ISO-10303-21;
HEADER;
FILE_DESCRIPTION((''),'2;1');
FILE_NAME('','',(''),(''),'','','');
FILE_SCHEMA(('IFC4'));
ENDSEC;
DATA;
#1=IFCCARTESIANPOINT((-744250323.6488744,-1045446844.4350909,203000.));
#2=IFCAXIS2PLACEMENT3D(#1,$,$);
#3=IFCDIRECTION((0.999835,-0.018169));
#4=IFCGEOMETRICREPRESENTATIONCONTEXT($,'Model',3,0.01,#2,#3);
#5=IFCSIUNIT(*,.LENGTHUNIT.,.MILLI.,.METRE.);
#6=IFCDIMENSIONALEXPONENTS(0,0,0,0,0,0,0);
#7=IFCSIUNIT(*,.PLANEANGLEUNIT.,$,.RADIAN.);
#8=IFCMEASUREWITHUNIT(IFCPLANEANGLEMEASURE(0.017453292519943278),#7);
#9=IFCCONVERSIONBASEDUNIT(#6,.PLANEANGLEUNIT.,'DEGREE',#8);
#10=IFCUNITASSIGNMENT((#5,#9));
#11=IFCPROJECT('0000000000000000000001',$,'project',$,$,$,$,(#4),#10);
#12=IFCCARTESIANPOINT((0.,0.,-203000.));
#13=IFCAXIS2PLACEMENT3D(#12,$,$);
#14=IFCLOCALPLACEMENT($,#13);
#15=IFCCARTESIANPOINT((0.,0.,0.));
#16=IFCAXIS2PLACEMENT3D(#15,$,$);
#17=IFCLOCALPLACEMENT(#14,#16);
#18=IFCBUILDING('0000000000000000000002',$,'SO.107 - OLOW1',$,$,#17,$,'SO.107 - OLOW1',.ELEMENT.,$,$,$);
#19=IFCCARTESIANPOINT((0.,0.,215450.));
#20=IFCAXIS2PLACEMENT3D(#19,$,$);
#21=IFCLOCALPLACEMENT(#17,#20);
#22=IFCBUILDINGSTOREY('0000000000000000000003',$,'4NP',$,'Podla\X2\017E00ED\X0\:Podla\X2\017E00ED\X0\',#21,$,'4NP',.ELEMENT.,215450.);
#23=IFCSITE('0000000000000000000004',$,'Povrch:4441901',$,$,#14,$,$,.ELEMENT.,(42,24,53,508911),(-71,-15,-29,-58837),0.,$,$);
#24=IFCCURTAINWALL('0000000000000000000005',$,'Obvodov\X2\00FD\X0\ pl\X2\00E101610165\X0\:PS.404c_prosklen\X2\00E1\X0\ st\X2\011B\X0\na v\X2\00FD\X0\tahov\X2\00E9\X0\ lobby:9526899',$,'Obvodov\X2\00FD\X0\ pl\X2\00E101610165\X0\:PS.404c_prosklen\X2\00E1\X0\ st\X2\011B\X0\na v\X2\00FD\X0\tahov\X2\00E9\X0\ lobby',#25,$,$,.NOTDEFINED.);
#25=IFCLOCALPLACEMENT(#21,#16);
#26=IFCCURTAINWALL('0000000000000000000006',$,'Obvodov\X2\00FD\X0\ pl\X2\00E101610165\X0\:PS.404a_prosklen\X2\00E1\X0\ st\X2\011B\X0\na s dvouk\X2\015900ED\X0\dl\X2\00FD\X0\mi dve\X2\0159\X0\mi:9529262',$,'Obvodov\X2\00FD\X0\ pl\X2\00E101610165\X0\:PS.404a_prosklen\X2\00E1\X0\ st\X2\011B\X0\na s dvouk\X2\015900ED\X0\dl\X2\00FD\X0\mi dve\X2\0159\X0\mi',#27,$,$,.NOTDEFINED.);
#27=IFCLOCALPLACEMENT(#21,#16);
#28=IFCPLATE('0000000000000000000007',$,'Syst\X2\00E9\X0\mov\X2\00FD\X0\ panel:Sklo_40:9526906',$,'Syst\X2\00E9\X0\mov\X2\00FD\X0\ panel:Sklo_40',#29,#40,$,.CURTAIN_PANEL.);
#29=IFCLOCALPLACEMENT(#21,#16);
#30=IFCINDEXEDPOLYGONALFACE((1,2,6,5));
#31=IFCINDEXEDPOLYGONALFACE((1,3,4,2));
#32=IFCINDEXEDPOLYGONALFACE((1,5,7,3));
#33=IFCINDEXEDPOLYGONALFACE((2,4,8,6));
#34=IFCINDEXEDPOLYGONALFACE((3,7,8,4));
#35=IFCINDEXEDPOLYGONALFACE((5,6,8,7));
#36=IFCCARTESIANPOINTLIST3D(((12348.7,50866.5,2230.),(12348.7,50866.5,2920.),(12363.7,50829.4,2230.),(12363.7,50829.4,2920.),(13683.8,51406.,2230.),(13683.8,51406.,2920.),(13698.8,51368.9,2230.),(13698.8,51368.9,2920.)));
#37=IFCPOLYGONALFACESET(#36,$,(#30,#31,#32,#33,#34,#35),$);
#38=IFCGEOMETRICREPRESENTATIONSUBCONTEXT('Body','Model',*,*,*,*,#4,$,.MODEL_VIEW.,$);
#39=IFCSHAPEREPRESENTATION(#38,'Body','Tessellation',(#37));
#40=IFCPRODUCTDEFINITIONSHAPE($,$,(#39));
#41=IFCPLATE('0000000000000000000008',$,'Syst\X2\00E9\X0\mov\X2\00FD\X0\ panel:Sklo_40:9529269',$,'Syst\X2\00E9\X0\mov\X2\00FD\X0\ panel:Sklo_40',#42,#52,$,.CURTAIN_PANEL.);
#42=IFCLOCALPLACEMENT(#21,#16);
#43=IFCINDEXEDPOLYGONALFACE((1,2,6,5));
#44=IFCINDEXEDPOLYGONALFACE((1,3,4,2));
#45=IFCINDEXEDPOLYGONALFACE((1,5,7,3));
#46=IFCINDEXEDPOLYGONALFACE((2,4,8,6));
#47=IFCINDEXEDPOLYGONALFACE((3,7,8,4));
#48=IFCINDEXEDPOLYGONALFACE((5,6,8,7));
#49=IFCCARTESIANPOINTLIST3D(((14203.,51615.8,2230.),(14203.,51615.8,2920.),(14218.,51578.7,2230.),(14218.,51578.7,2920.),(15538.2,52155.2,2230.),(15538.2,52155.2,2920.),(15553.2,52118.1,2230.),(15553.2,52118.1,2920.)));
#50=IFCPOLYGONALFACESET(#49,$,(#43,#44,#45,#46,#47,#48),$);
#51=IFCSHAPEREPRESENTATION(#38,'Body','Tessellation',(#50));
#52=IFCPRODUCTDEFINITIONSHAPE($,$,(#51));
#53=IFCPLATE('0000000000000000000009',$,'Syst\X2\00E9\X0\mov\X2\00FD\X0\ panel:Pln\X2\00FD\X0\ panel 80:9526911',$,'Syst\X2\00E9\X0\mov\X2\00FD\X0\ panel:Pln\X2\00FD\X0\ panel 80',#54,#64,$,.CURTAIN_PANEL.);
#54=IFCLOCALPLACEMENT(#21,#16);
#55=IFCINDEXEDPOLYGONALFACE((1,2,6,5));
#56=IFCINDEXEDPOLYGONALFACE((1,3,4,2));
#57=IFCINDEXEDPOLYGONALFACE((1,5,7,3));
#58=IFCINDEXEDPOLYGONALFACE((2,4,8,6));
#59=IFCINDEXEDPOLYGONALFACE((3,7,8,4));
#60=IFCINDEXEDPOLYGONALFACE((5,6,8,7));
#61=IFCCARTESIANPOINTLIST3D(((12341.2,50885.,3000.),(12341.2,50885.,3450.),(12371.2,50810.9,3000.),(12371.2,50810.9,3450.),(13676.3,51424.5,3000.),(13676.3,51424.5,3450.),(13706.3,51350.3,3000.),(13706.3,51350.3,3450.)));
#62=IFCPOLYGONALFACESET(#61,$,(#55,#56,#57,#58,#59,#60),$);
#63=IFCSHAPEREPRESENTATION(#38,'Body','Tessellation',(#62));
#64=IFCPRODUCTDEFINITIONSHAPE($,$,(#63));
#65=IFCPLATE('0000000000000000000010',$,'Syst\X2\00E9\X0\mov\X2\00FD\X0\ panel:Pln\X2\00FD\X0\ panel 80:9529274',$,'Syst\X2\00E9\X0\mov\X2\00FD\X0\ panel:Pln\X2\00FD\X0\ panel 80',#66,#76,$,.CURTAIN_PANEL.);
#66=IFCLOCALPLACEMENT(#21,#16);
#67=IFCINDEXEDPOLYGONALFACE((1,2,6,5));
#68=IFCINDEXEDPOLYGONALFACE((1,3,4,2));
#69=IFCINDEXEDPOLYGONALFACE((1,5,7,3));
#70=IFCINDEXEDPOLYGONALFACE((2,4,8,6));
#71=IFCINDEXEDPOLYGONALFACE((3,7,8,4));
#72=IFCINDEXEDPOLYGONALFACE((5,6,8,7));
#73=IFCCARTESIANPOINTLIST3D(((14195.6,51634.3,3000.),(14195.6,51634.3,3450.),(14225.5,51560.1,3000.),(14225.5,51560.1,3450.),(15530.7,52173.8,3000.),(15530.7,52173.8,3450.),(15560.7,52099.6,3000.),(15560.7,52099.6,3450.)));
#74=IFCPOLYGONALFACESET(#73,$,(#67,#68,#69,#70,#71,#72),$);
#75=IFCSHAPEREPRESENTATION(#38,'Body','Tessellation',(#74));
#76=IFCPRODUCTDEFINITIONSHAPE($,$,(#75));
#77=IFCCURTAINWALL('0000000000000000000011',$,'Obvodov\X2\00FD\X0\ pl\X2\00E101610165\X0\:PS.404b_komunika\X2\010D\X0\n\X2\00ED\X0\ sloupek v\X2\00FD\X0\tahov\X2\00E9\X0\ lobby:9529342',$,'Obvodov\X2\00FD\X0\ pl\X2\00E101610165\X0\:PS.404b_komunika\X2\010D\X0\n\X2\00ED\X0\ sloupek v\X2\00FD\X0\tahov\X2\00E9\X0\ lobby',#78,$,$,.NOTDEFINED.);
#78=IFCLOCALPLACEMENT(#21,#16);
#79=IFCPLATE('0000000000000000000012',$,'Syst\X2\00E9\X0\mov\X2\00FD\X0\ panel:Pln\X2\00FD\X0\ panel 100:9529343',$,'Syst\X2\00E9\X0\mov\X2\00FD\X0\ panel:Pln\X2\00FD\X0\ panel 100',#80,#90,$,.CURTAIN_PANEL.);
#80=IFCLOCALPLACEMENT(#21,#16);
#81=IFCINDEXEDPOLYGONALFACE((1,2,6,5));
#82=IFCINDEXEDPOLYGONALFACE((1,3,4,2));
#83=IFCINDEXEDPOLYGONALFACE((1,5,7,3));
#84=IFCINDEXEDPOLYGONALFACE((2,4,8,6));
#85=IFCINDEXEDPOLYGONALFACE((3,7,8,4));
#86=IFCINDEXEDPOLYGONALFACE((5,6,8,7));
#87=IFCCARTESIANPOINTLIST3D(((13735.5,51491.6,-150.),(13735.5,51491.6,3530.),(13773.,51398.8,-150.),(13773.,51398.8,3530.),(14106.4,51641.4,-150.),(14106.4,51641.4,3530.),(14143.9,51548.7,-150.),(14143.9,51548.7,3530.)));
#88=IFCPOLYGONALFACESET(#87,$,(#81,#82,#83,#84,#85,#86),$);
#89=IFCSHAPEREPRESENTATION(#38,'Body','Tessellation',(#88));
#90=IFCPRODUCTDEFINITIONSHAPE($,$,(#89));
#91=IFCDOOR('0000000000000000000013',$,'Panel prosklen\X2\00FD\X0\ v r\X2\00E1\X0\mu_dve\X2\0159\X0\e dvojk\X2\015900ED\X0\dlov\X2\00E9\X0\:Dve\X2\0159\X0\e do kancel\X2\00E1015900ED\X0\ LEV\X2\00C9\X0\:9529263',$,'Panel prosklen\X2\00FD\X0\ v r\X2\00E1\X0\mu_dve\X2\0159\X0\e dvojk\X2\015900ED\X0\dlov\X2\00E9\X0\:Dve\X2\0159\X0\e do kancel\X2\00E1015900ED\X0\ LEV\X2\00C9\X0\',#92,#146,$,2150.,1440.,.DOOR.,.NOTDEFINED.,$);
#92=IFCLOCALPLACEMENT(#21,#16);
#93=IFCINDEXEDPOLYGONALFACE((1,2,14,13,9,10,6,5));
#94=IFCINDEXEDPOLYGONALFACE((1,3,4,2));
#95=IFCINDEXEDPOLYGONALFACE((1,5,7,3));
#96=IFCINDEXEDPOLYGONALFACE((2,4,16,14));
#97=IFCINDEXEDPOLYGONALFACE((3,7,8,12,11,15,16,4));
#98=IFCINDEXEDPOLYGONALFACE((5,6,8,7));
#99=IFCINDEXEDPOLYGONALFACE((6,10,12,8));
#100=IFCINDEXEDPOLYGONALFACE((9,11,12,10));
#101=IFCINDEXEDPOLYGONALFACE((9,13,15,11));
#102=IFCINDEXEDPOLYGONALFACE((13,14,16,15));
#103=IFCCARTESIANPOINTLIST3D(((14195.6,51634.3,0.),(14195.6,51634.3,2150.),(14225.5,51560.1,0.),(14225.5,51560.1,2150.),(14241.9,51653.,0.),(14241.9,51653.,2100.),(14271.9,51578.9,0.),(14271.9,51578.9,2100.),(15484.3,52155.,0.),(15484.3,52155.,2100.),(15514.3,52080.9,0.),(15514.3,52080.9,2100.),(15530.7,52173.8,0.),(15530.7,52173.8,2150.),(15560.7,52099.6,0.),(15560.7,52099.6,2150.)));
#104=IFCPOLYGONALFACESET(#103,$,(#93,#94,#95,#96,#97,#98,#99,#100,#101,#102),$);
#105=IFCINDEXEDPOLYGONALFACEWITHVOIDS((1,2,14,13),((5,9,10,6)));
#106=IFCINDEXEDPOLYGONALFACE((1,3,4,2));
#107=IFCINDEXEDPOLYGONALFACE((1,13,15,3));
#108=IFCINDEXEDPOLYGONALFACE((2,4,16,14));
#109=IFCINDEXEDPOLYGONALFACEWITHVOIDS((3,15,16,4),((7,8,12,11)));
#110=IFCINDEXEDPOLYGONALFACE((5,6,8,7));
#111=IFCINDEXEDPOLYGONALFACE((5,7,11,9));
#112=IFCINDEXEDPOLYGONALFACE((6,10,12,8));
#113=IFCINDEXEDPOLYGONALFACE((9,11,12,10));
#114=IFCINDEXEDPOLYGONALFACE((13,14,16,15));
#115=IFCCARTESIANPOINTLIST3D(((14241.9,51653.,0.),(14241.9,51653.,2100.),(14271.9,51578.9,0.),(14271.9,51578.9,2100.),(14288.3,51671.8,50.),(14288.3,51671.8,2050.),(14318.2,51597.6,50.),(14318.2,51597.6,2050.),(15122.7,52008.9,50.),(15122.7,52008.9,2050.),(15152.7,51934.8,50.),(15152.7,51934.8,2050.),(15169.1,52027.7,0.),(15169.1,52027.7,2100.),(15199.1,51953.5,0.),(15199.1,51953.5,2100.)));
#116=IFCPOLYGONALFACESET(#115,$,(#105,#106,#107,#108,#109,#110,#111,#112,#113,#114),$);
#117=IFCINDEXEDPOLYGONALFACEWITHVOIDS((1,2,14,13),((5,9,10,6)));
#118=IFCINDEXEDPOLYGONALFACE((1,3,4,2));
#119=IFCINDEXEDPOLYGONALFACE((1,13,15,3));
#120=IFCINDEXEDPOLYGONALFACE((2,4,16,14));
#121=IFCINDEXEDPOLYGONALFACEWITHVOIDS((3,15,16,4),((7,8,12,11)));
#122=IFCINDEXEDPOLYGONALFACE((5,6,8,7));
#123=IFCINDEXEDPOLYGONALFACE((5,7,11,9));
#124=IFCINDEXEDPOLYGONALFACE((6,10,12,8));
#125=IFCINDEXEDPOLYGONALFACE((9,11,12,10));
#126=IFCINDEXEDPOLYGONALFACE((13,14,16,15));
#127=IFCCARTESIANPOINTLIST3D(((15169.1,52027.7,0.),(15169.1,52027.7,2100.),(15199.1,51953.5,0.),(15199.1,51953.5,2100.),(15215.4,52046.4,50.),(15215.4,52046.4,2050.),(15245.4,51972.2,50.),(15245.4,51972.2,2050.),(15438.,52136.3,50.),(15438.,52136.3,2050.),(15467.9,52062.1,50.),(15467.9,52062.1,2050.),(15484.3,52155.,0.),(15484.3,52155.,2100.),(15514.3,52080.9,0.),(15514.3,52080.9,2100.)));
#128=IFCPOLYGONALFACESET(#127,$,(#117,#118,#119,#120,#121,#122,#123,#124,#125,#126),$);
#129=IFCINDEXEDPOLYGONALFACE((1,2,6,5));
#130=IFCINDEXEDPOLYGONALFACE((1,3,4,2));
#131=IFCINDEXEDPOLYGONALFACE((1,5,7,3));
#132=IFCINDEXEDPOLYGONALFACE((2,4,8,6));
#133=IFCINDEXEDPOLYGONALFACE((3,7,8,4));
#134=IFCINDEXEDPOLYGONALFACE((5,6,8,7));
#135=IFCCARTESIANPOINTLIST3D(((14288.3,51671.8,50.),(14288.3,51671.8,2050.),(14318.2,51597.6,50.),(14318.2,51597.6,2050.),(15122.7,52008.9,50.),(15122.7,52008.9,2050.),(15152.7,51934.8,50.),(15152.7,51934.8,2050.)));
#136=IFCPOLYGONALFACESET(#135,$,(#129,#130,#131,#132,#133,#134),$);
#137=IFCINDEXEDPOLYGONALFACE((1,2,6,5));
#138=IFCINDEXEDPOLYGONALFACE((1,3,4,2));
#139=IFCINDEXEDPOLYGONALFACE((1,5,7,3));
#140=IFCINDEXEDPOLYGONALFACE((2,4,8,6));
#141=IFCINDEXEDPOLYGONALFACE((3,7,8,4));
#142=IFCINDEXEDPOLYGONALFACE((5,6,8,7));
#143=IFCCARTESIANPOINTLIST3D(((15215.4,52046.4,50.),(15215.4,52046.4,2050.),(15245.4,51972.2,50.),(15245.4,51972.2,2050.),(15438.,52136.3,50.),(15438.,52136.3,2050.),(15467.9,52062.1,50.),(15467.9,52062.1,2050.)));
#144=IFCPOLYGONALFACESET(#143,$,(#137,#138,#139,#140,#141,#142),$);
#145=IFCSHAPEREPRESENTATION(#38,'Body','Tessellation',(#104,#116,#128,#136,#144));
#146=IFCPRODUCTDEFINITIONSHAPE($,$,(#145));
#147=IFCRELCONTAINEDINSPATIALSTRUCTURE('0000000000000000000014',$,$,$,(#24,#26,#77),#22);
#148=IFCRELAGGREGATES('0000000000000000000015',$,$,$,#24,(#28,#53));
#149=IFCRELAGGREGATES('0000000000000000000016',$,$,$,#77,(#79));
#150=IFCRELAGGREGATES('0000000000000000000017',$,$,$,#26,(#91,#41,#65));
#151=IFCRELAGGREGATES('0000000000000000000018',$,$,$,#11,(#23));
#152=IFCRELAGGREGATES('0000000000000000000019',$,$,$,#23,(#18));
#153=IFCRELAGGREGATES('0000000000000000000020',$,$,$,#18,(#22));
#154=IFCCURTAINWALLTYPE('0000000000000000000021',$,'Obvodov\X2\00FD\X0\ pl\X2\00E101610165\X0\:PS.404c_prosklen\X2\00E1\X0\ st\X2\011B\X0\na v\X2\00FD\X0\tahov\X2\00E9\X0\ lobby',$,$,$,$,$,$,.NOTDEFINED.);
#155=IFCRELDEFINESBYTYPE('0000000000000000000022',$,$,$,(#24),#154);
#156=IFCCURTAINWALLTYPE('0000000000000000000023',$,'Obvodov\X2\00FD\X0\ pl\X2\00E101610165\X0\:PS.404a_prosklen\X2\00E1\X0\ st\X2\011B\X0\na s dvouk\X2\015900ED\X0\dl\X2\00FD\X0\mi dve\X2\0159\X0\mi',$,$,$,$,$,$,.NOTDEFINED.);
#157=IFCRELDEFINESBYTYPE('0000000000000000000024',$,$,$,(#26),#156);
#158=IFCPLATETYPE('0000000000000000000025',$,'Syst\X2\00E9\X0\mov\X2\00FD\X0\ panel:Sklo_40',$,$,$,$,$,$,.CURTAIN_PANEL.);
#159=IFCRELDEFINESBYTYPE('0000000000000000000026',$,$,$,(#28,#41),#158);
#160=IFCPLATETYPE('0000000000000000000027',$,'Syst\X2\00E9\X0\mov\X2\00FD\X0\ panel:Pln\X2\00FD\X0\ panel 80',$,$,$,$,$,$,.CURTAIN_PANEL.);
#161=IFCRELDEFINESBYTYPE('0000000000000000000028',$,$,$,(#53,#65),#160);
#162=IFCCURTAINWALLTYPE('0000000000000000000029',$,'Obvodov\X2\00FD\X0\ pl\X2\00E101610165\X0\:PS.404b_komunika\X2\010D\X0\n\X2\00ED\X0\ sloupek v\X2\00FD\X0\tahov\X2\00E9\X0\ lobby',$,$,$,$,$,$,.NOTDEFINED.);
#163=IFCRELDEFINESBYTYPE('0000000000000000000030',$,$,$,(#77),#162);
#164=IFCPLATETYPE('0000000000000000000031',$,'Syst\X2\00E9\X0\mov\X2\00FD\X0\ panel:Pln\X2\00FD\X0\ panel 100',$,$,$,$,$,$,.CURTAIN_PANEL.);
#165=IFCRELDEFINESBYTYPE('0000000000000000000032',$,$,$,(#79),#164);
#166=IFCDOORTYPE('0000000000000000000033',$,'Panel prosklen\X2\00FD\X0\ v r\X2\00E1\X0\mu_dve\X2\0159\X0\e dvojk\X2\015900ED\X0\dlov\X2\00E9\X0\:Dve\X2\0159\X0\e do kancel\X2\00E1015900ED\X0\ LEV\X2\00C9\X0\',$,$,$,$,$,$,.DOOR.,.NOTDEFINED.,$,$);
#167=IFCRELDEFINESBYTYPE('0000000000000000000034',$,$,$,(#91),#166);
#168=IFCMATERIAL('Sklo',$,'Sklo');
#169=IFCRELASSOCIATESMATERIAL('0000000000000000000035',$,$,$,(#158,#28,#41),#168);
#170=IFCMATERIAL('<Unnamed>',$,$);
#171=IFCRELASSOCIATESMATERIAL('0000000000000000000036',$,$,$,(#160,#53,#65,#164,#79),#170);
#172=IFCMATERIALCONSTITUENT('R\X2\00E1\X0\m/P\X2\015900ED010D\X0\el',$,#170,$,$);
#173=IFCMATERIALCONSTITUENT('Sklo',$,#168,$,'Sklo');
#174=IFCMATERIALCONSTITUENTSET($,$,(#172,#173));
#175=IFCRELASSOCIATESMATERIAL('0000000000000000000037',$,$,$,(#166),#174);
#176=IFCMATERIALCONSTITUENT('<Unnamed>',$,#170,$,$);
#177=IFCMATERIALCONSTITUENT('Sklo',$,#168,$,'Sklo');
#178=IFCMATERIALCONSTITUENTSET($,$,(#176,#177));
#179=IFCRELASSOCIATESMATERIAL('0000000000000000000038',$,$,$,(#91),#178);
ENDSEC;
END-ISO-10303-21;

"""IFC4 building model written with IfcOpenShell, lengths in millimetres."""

from ifc_helpers import new_model, entity, si_unit, converted_unit, direction, frame, origin, place, context, subcontext, project, spatial, indexed_curve, outline, extrude, source, transform, mapped, material, constituent, constituent_set, type_object, type_shapes, element, aggregate, save


model = new_model("IFC4")

# Units and contexts
model_context = context("Model", 3, precision=0.01, world=frame((-744250323.6488744, -1045446844.4350909, 203000.0)), true_north=direction((0.999835, -0.018169)))
body_context = subcontext(model_context, "Body", "Model", "MODEL_VIEW")
ifc_project = project(units=[si_unit("LENGTHUNIT", "METRE", prefix="MILLI"), converted_unit("PLANEANGLEUNIT", "DEGREE", entity("IfcPlaneAngleMeasure", 0.017453292519943278), si_unit("PLANEANGLEUNIT", "RADIAN"), dimensions=[0, 0, 0, 0, 0, 0, 0])], contexts=[model_context])

# Site, building, storey
site_placement = place(None, frame((0.0, 0.0, -203000.0)))
site = spatial("IfcSite", under=ifc_project, at=site_placement, Name="Povrch:4441901", CompositionType="ELEMENT", RefLatitude=(42, 24, 53, 508911), RefLongitude=(-71, -15, -29, -58837), RefElevation=0.0)
building_placement = place(site_placement, origin())
building = spatial("IfcBuilding", under=site, at=building_placement, Name="SO.107 - OLOW1", LongName="SO.107 - OLOW1", CompositionType="ELEMENT")
storey_placement = place(building_placement, frame((0.0, 0.0, 215450.0)))
storey = spatial("IfcBuildingStorey", under=building, at=storey_placement, Name="4NP", ObjectType="Podlaží:Podlaží", LongName="4NP", CompositionType="ELEMENT", Elevation=215450.0)

# Curtain walls
curtain_wall_type_1 = type_object("IfcCurtainWallType", Name="Obvodový plášť:PS.404c_prosklená stěna výtahové lobby", PredefinedType="NOTDEFINED")
curtain_wall_1_placement = place(storey_placement, frame((0.0, 0.0, -215450.0)))
curtain_wall_1 = element("IfcCurtainWall", 1, at=curtain_wall_1_placement, inside=storey, type_object=curtain_wall_type_1, Name="Obvodový plášť:PS.404c_prosklená stěna výtahové lobby:9526899", ObjectType="Obvodový plášť:PS.404c_prosklená stěna výtahové lobby", PredefinedType="NOTDEFINED")
ifc_material_1 = material(Name="<Unnamed>")
curtain_wall_type_2 = type_object("IfcCurtainWallType", Name="Obvodový plášť:PS.404a_prosklená stěna s dvoukřídlými dveřmi", PredefinedType="NOTDEFINED")
curtain_wall_2_placement = place(storey_placement, frame((0.0, 0.0, -215450.0)))
curtain_wall_2 = element("IfcCurtainWall", 2, at=curtain_wall_2_placement, inside=storey, type_object=curtain_wall_type_2, Name="Obvodový plášť:PS.404a_prosklená stěna s dvoukřídlými dveřmi:9529262", ObjectType="Obvodový plášť:PS.404a_prosklená stěna s dvoukřídlými dveřmi", PredefinedType="NOTDEFINED")

# Plates
ifc_material_2 = material(Name="Sklo", Category="Sklo")
plate_type_1 = type_object("IfcPlateType", Name="Systémový panel:Sklo_40", PredefinedType="CURTAIN_PANEL", material=ifc_material_2)
shared_shape_1 = source(origin(), body_context, "Body", "SweptSolid", [
    extrude(outline(indexed_curve([(-20.0, -720.0), (20.0, -720.0), (20.0, 720.0), (-20.0, 720.0), (-20.0, -720.0)], self_intersect=False)), frame((0.0, 0.0, 0.0), z_axis=(0.0, 0.0, 1.0), x_axis=(0.0, 1.0, 0.0)), (0.0, 0.0, 1.0), 690.0),
])
type_shapes(plate_type_1, [shared_shape_1])
plate_1_placement = place(curtain_wall_1_placement, frame((13023.8, 51117.7, 217680.0), z_axis=(0.0, 0.0, 1.0), x_axis=(0.927176, 0.374626, 0.0)))
plate_1 = element("IfcPlate", 3, at=plate_1_placement, type_object=plate_type_1, material=ifc_material_2, Name="Systémový panel:Sklo_40:9526906", ObjectType="Systémový panel:Sklo_40", PredefinedType="CURTAIN_PANEL", context=body_context, shape_type="MappedRepresentation", body=[
    mapped(shared_shape_1, transform((0.0, 0.0, 0.0), scale=1.0)),
])
plate_2_placement = place(curtain_wall_2_placement, frame((14878.1, 51866.9, 217680.0), z_axis=(0.0, 0.0, 1.0), x_axis=(-0.927176, -0.374626, 0.0)))
plate_2 = element("IfcPlate", 4, at=plate_2_placement, type_object=plate_type_1, material=ifc_material_2, Name="Systémový panel:Sklo_40:9529269", ObjectType="Systémový panel:Sklo_40", PredefinedType="CURTAIN_PANEL", context=body_context, shape_type="MappedRepresentation", body=[
    mapped(shared_shape_1, transform((0.0, 0.0, 0.0), scale=1.0)),
])
plate_type_2 = type_object("IfcPlateType", Name="Systémový panel:Plný panel 80", PredefinedType="CURTAIN_PANEL", material=ifc_material_1)
shared_shape_2 = source(origin(), body_context, "Body", "SweptSolid", [
    extrude(outline(indexed_curve([(-40.0, -720.0), (40.0, -720.0), (40.0, 720.0), (-40.0, 720.0), (-40.0, -720.0)], self_intersect=False)), frame((0.0, 0.0, 0.0), z_axis=(0.0, 0.0, 1.0), x_axis=(0.0, 1.0, 0.0)), (0.0, 0.0, 1.0), 450.0),
])
type_shapes(plate_type_2, [shared_shape_2])
plate_3_placement = place(curtain_wall_1_placement, frame((13023.8, 51117.7, 218450.0), z_axis=(0.0, 0.0, 1.0), x_axis=(0.927176, 0.374626, 0.0)))
plate_3 = element("IfcPlate", 5, at=plate_3_placement, type_object=plate_type_2, material=ifc_material_1, Name="Systémový panel:Plný panel 80:9526911", ObjectType="Systémový panel:Plný panel 80", PredefinedType="CURTAIN_PANEL", context=body_context, shape_type="MappedRepresentation", body=[
    mapped(shared_shape_2, transform((0.0, 0.0, 0.0), scale=1.0)),
])
aggregate(curtain_wall_1, [plate_1, plate_3])
plate_4_placement = place(curtain_wall_2_placement, frame((14878.1, 51866.9, 218450.0), z_axis=(0.0, 0.0, 1.0), x_axis=(-0.927176, -0.374626, 0.0)))
plate_4 = element("IfcPlate", 6, at=plate_4_placement, type_object=plate_type_2, material=ifc_material_1, Name="Systémový panel:Plný panel 80:9529274", ObjectType="Systémový panel:Plný panel 80", PredefinedType="CURTAIN_PANEL", context=body_context, shape_type="MappedRepresentation", body=[
    mapped(shared_shape_2, transform((0.0, 0.0, 0.0), scale=1.0)),
])

# Curtain wall, plate
curtain_wall_type_3 = type_object("IfcCurtainWallType", Name="Obvodový plášť:PS.404b_komunikační sloupek výtahové lobby", PredefinedType="NOTDEFINED")
curtain_wall_3_placement = place(storey_placement, frame((0.0, 0.0, -215450.0)))
curtain_wall_3 = element("IfcCurtainWall", 7, at=curtain_wall_3_placement, inside=storey, type_object=curtain_wall_type_3, Name="Obvodový plášť:PS.404b_komunikační sloupek výtahové lobby:9529342", ObjectType="Obvodový plášť:PS.404b_komunikační sloupek výtahové lobby", PredefinedType="NOTDEFINED")
plate_type_3 = type_object("IfcPlateType", Name="Systémový panel:Plný panel 100", PredefinedType="CURTAIN_PANEL", material=ifc_material_1)
shared_shape_3 = source(origin(), body_context, "Body", "SweptSolid", [
    extrude(outline(indexed_curve([(-50.0, -200.0), (50.0, -200.0), (50.0, 200.0), (-50.0, 200.0), (-50.0, -200.0)], self_intersect=False)), frame((0.0, 50.0, 0.0), z_axis=(0.0, 0.0, 1.0), x_axis=(0.0, 1.0, 0.0)), (0.0, 0.0, 1.0), 3680.0),
])
type_shapes(plate_type_3, [shared_shape_3])
plate_5_placement = place(curtain_wall_3_placement, frame((13958.4, 51473.8, 215300.0), z_axis=(0.0, 0.0, 1.0), x_axis=(0.927176, 0.374626, 0.0)))
plate_5 = element("IfcPlate", 8, at=plate_5_placement, type_object=plate_type_3, material=ifc_material_1, Name="Systémový panel:Plný panel 100:9529343", ObjectType="Systémový panel:Plný panel 100", PredefinedType="CURTAIN_PANEL", context=body_context, shape_type="MappedRepresentation", body=[
    mapped(shared_shape_3, transform((0.0, 0.0, 0.0), scale=1.0)),
])
aggregate(curtain_wall_3, [plate_5])

# Door
ifc_constituent_1 = constituent(ifc_material_1, Name="<Unnamed>")
ifc_constituent_2 = constituent(ifc_material_2, Name="Sklo", Category="Sklo")
ifc_constituent_set_1 = constituent_set(constituents=[ifc_constituent_1, ifc_constituent_2])
ifc_constituent_3 = constituent(ifc_material_1, Name="Rám/Příčel")
ifc_constituent_4 = constituent(ifc_material_2, Name="Sklo", Category="Sklo")
ifc_constituent_set_2 = constituent_set(constituents=[ifc_constituent_3, ifc_constituent_4])
door_type = type_object("IfcDoorType", Name="Panel prosklený v rámu_dveře dvojkřídlové:Dveře do kanceláří LEVÉ", OperationType="NOTDEFINED", PredefinedType="DOOR", material=ifc_constituent_set_2)
shared_shape_4 = source(origin(), body_context, "Body", "SweptSolid", [
    extrude(outline(indexed_curve([(-720.0, -1087.5), (720.0, -1087.5), (720.0, 1062.5), (670.0, 1062.5), (670.0, -1037.5), (-670.0, -1037.5), (-670.0, 1062.5), (-720.0, 1062.5), (-720.0, -1087.5)], self_intersect=False)), frame((0.0, 40.0, 1062.5), z_axis=(0.0, -1.0, 0.0), x_axis=(-1.0, 0.0, 0.0)), (0.0, 0.0, 1.0), 80.0),
    extrude(outline(indexed_curve([(-1050.0, -500.0), (1050.0, -500.0), (1050.0, 500.0), (-1050.0, 500.0), (-1050.0, -500.0)], self_intersect=False), holes=[indexed_curve([(-1000.0, -450.0), (-1000.0, 450.0), (1000.0, 450.0), (1000.0, -450.0), (-1000.0, -450.0)], self_intersect=False)]), frame((-170.0, 40.0, 1050.0), z_axis=(0.0, -1.0, 0.0), x_axis=(0.0, 0.0, -1.0)), (0.0, 0.0, 1.0), 80.0),
    extrude(outline(indexed_curve([(-1050.0, -170.0), (1050.0, -170.0), (1050.0, 170.0), (-1050.0, 170.0), (-1050.0, -170.0)], self_intersect=False), holes=[indexed_curve([(-1000.0, -120.0), (-1000.0, 120.0), (1000.0, 120.0), (1000.0, -120.0), (-1000.0, -120.0)], self_intersect=False)]), frame((500.0, 40.0, 1050.0), z_axis=(0.0, -1.0, 0.0), x_axis=(0.0, 0.0, -1.0)), (0.0, 0.0, 1.0), 80.0),
    extrude(outline(indexed_curve([(-450.0, -40.0), (450.0, -40.0), (450.0, 40.0), (-450.0, 40.0), (-450.0, -40.0)], self_intersect=False)), frame((-170.0, 0.0, 50.0)), (0.0, 0.0, 1.0), 2000.0),
    extrude(outline(indexed_curve([(-120.0, -40.0), (120.0, -40.0), (120.0, 40.0), (-120.0, 40.0), (-120.0, -40.0)], self_intersect=False)), frame((500.0, 0.0, 50.0)), (0.0, 0.0, 1.0), 2000.0),
])
type_shapes(door_type, [shared_shape_4])
door_placement = place(curtain_wall_2_placement, frame((14878.1, 51866.9, 215450.0), z_axis=(0.0, 0.0, 1.0), x_axis=(0.927176, 0.374626, 0.0)))
door = element("IfcDoor", 9, at=door_placement, type_object=door_type, material=ifc_constituent_set_1, Name="Panel prosklený v rámu_dveře dvojkřídlové:Dveře do kanceláří LEVÉ:9529263", ObjectType="Panel prosklený v rámu_dveře dvojkřídlové:Dveře do kanceláří LEVÉ", OperationType="NOTDEFINED", OverallHeight=2150.0, OverallWidth=1440.0, PredefinedType="DOOR", context=body_context, shape_type="MappedRepresentation", body=[
    mapped(shared_shape_4, transform((0.0, 0.0, 0.0), scale=1.0)),
])
aggregate(curtain_wall_2, [door, plate_2, plate_4])

save(model, "model.ifc")
